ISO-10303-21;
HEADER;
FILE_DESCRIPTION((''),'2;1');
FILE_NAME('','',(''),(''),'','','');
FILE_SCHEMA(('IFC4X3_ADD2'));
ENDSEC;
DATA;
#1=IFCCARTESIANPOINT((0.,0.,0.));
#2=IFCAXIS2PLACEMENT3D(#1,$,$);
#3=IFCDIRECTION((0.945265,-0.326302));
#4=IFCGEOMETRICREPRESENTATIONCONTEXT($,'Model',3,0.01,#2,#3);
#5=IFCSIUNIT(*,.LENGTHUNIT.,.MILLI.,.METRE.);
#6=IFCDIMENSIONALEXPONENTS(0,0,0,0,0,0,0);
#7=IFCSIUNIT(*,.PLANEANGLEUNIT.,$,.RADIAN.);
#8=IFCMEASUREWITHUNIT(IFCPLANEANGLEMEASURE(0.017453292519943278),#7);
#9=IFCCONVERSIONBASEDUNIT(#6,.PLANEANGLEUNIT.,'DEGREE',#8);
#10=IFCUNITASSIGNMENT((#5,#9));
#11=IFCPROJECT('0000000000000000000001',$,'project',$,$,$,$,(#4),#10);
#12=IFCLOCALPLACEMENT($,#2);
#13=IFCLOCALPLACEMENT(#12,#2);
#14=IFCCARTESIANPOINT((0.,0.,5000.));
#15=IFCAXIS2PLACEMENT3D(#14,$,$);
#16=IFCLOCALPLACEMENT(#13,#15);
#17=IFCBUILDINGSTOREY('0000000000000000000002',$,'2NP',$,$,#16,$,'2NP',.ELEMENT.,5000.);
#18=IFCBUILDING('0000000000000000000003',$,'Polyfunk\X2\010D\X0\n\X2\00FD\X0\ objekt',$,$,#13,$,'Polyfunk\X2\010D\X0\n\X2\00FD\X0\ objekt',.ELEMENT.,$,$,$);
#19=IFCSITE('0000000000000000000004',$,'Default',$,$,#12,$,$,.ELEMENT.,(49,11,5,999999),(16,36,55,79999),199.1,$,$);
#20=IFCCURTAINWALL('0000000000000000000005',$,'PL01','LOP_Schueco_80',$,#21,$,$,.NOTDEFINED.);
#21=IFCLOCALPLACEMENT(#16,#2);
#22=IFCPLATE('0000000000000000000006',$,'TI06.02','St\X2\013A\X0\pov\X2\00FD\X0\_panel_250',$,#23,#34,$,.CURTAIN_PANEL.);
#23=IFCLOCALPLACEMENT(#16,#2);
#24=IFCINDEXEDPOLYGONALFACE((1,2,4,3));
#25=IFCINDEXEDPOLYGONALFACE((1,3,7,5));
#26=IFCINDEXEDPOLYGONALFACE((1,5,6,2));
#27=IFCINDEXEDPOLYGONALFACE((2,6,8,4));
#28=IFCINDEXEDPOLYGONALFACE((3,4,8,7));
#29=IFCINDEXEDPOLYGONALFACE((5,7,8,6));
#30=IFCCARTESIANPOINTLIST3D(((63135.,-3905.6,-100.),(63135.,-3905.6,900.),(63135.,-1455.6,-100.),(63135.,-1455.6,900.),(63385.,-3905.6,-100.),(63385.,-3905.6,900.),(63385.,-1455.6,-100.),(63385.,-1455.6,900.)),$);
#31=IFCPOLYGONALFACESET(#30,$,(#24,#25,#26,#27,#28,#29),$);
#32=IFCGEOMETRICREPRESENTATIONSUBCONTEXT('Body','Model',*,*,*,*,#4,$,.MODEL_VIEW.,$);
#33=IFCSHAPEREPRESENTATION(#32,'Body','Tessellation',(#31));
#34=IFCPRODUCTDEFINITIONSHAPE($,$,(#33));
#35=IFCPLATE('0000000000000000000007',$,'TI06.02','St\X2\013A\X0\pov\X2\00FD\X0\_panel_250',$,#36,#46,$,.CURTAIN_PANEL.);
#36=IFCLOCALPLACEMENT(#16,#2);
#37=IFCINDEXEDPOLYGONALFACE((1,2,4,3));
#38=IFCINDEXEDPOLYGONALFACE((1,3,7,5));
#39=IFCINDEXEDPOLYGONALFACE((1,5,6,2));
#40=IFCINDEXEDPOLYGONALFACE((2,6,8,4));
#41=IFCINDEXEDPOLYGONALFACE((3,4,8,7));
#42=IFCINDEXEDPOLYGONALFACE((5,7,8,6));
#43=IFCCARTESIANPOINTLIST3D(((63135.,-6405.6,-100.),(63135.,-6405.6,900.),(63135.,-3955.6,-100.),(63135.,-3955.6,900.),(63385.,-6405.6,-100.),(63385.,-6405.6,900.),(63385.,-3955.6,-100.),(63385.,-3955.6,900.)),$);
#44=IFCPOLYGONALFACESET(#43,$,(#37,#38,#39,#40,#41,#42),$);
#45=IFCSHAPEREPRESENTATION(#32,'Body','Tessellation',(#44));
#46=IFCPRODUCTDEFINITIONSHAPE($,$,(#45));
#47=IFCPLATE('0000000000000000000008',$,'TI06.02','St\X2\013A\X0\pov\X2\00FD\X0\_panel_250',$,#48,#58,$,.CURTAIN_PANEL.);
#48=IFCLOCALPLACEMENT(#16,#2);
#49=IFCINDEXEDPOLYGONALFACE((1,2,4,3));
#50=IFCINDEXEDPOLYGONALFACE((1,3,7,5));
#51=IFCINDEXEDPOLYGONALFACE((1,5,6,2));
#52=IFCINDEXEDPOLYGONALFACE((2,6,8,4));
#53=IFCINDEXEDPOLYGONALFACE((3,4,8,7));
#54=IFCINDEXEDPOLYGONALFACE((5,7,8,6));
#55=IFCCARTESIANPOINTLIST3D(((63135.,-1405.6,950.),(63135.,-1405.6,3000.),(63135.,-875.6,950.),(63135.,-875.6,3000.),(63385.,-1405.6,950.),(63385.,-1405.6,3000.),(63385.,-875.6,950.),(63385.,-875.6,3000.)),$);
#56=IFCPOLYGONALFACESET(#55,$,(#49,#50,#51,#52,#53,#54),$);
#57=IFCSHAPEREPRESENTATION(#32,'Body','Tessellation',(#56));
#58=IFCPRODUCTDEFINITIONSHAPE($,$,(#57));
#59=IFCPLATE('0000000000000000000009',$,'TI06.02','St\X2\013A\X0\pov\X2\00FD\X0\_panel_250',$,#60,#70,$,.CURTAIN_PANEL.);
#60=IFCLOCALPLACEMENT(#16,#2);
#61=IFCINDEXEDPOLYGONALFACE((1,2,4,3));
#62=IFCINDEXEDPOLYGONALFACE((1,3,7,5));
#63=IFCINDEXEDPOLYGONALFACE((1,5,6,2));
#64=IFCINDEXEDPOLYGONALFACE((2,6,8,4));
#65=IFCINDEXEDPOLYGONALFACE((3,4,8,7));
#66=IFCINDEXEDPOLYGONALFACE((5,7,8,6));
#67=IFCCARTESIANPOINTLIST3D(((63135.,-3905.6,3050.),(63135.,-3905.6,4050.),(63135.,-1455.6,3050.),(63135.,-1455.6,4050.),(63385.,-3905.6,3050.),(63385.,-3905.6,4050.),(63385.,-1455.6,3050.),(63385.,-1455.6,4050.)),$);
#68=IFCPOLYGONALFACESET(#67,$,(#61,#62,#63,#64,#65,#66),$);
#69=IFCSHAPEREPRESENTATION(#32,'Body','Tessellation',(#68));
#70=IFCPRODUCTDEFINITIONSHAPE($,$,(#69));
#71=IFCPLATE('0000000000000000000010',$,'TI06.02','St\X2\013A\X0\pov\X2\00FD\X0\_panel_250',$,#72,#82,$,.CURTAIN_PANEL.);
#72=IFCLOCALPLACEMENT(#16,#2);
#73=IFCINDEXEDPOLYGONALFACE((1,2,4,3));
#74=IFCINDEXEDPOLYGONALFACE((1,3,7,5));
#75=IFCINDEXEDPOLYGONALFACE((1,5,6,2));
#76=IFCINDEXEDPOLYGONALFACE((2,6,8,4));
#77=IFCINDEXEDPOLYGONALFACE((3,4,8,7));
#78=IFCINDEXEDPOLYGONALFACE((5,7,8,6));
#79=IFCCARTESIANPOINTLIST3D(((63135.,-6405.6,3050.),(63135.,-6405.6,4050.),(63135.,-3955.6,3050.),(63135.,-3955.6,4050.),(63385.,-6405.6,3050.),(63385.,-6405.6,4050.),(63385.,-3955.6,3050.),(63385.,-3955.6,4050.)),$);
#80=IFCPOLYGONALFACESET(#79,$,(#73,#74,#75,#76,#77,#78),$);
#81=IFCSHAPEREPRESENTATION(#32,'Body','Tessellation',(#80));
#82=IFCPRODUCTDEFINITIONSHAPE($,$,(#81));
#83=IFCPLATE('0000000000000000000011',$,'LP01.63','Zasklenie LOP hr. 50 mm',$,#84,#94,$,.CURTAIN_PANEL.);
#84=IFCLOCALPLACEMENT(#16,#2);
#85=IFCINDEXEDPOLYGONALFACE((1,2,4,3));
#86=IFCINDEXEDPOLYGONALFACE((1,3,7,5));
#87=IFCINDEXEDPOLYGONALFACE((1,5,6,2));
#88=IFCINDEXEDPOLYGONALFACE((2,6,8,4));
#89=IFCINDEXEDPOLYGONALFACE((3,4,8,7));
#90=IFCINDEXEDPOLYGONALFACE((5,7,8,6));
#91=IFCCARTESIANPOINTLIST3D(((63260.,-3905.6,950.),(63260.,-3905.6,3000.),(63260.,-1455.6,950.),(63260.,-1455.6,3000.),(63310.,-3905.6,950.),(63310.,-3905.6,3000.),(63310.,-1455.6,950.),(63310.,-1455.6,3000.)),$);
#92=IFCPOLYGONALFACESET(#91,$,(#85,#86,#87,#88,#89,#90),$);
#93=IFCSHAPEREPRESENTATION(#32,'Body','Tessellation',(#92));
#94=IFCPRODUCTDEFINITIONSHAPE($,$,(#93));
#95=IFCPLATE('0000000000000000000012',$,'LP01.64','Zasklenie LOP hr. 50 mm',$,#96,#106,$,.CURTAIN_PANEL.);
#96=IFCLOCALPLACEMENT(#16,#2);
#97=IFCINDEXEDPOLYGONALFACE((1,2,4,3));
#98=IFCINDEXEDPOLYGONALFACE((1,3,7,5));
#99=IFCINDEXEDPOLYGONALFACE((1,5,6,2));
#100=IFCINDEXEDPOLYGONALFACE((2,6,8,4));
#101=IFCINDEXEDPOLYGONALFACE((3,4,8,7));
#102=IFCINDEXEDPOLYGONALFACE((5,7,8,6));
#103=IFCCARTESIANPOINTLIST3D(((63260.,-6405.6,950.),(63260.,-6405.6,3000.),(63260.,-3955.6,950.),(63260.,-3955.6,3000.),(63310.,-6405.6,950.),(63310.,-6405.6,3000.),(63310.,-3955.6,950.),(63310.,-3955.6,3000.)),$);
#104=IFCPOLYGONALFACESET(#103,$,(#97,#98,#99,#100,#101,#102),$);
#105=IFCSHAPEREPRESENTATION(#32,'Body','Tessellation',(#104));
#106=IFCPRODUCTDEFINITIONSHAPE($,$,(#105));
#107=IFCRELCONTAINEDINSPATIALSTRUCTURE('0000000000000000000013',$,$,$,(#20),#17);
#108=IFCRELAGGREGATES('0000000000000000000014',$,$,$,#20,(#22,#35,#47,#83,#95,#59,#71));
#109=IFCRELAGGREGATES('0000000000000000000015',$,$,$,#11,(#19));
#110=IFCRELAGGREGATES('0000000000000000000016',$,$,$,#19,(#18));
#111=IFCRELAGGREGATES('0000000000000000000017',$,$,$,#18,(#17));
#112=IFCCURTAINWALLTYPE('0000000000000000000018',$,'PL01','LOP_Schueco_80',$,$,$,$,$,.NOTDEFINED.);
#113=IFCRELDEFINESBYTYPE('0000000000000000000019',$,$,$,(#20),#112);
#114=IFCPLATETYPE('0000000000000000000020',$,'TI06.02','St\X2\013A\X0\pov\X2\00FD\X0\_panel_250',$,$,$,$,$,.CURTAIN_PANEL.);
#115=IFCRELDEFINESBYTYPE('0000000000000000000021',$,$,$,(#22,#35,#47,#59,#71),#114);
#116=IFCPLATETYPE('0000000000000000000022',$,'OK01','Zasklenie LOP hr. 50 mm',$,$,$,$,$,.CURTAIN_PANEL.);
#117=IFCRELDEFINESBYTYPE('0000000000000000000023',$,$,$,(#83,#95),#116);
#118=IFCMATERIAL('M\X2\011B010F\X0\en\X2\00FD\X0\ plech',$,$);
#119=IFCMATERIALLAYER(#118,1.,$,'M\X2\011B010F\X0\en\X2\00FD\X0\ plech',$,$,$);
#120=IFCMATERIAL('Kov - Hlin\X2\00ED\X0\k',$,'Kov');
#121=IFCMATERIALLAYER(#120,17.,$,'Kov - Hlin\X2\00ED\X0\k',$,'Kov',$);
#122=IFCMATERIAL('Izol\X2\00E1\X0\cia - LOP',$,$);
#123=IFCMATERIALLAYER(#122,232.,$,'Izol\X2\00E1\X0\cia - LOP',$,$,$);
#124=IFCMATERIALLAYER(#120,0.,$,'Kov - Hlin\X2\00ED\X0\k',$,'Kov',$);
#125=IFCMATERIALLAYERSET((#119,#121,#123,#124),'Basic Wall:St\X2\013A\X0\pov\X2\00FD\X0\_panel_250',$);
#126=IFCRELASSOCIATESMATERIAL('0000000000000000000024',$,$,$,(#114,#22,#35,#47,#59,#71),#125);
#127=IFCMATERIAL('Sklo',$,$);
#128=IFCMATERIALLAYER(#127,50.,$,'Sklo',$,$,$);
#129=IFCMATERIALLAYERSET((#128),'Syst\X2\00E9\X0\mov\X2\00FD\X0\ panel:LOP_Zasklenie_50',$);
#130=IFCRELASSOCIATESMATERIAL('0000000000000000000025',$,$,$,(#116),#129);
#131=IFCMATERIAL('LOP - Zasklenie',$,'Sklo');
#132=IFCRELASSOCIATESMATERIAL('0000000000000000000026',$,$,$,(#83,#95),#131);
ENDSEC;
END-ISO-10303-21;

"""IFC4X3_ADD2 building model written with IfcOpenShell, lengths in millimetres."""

from ifc_helpers import new_model, entity, si_unit, converted_unit, direction, frame, frame_2d, origin, origin_2d_with_axis, place, context, subcontext, project, spatial, rectangle, extrude, source, transform, mapped, material, layer, layer_set, layer_usage, type_object, type_shapes, element, aggregate, save


model = new_model("IFC4X3_ADD2")

# Units and contexts
model_context = context("Model", 3, precision=0.01, world=origin(), true_north=direction((0.945265, -0.326302)))
body_context = subcontext(model_context, "Body", "Model", "MODEL_VIEW")
ifc_project = project(units=[si_unit("LENGTHUNIT", "METRE", prefix="MILLI"), converted_unit("PLANEANGLEUNIT", "DEGREE", entity("IfcPlaneAngleMeasure", 0.017453292519943278), si_unit("PLANEANGLEUNIT", "RADIAN"), dimensions=[0, 0, 0, 0, 0, 0, 0])], contexts=[model_context])

# Site, building, storey
site_placement = place(None, origin())
site = spatial("IfcSite", under=ifc_project, at=site_placement, Name="Default", CompositionType="ELEMENT", RefLatitude=(49, 11, 5, 999999), RefLongitude=(16, 36, 55, 79999), RefElevation=199.1)
building_placement = place(site_placement, origin())
building = spatial("IfcBuilding", under=site, at=building_placement, Name="Polyfunkčný objekt", LongName="Polyfunkčný objekt", CompositionType="ELEMENT")
storey_placement = place(building_placement, frame((0.0, 0.0, 5000.0)))
storey = spatial("IfcBuildingStorey", under=building, at=storey_placement, Name="2NP", LongName="2NP", CompositionType="ELEMENT", Elevation=5000.0)

# Curtain wall, plates
curtain_wall_type = type_object("IfcCurtainWallType", Name="PL01", Description="LOP_Schueco_80", PredefinedType="NOTDEFINED")
curtain_wall_placement = place(storey_placement, frame((0.0, 0.0, -5000.0)))
curtain_wall = element("IfcCurtainWall", 1, at=curtain_wall_placement, inside=storey, type_object=curtain_wall_type, Name="PL01", Description="LOP_Schueco_80", PredefinedType="NOTDEFINED")
ifc_material_1 = material(Name="Měďený plech")
ifc_layer_1 = layer(ifc_material_1, 1.0, Name="Měďený plech")
ifc_material_2 = material(Name="Kov - Hliník", Category="Kov")
ifc_layer_2 = layer(ifc_material_2, 17.0, Name="Kov - Hliník", Category="Kov")
ifc_material_3 = material(Name="Izolácia - LOP")
ifc_layer_3 = layer(ifc_material_3, 232.0, Name="Izolácia - LOP")
ifc_layer_4 = layer(ifc_material_2, 0.0, Name="Kov - Hliník", Category="Kov")
ifc_layer_set_1 = layer_set([ifc_layer_1, ifc_layer_2, ifc_layer_3, ifc_layer_4], Name="Basic Wall:Stĺpový_panel_250")
ifc_layer_usage_1 = layer_usage(ifc_layer_set_1, "AXIS2", "NEGATIVE", 125.0)
plate_type_1 = type_object("IfcPlateType", Name="TI06.02", Description="Stĺpový_panel_250", PredefinedType="CURTAIN_PANEL", material=ifc_layer_set_1)
plate_1_placement = place(storey_placement, frame((63260.0, -1455.6, -100.0), z_axis=(0.0, 0.0, 1.0), x_axis=(0.0, -1.0, 0.0)))
plate_1 = element("IfcPlate", 2, at=plate_1_placement, type_object=plate_type_1, material=ifc_layer_usage_1, Name="TI06.02", Description="Stĺpový_panel_250", PredefinedType="CURTAIN_PANEL", context=body_context, shape_type="SweptSolid", body=[
    extrude(rectangle(XDim=250.0, YDim=2450.0, at=frame_2d((0.0, 0.0), x_axis=(1.0, 0.0))), frame((1225.0, 0.0, 0.0), z_axis=(0.0, 0.0, 1.0), x_axis=(0.0, 1.0, 0.0)), (0.0, 0.0, 1.0), 1000.0),
])
ifc_layer_usage_2 = layer_usage(ifc_layer_set_1, "AXIS2", "NEGATIVE", 125.0)
plate_2_placement = place(storey_placement, frame((63260.0, -3955.6, -100.0), z_axis=(0.0, 0.0, 1.0), x_axis=(0.0, -1.0, 0.0)))
plate_2 = element("IfcPlate", 3, at=plate_2_placement, type_object=plate_type_1, material=ifc_layer_usage_2, Name="TI06.02", Description="Stĺpový_panel_250", PredefinedType="CURTAIN_PANEL", context=body_context, shape_type="SweptSolid", body=[
    extrude(rectangle(XDim=250.0, YDim=2450.0, at=frame_2d((0.0, 0.0), x_axis=(1.0, 0.0))), frame((1225.0, 0.0, 0.0), z_axis=(0.0, 0.0, 1.0), x_axis=(0.0, 1.0, 0.0)), (0.0, 0.0, 1.0), 1000.0),
])
ifc_layer_usage_3 = layer_usage(ifc_layer_set_1, "AXIS2", "NEGATIVE", 125.0)
plate_3_placement = place(storey_placement, frame((63260.0, -875.6, 950.0), z_axis=(0.0, 0.0, 1.0), x_axis=(0.0, -1.0, 0.0)))
plate_3 = element("IfcPlate", 4, at=plate_3_placement, type_object=plate_type_1, material=ifc_layer_usage_3, Name="TI06.02", Description="Stĺpový_panel_250", PredefinedType="CURTAIN_PANEL", context=body_context, shape_type="SweptSolid", body=[
    extrude(rectangle(XDim=250.0, YDim=530.0, at=frame_2d((0.0, 0.0), x_axis=(1.0, 0.0))), frame((265.0, 0.0, 0.0), z_axis=(0.0, 0.0, 1.0), x_axis=(0.0, 1.0, 0.0)), (0.0, 0.0, 1.0), 2050.0),
])
ifc_layer_usage_4 = layer_usage(ifc_layer_set_1, "AXIS2", "NEGATIVE", 125.0)
plate_4_placement = place(storey_placement, frame((63260.0, -1455.6, 3050.0), z_axis=(0.0, 0.0, 1.0), x_axis=(0.0, -1.0, 0.0)))
plate_4 = element("IfcPlate", 5, at=plate_4_placement, type_object=plate_type_1, material=ifc_layer_usage_4, Name="TI06.02", Description="Stĺpový_panel_250", PredefinedType="CURTAIN_PANEL", context=body_context, shape_type="SweptSolid", body=[
    extrude(rectangle(XDim=250.0, YDim=2450.0, at=frame_2d((0.0, 0.0), x_axis=(1.0, 0.0))), frame((1225.0, 0.0, 0.0), z_axis=(0.0, 0.0, 1.0), x_axis=(0.0, 1.0, 0.0)), (0.0, 0.0, 1.0), 1000.0),
])
ifc_layer_usage_5 = layer_usage(ifc_layer_set_1, "AXIS2", "NEGATIVE", 125.0)
plate_5_placement = place(storey_placement, frame((63260.0, -3955.6, 3050.0), z_axis=(0.0, 0.0, 1.0), x_axis=(0.0, -1.0, 0.0)))
plate_5 = element("IfcPlate", 6, at=plate_5_placement, type_object=plate_type_1, material=ifc_layer_usage_5, Name="TI06.02", Description="Stĺpový_panel_250", PredefinedType="CURTAIN_PANEL", context=body_context, shape_type="SweptSolid", body=[
    extrude(rectangle(XDim=250.0, YDim=2450.0, at=frame_2d((0.0, 0.0), x_axis=(1.0, 0.0))), frame((1225.0, 0.0, 0.0), z_axis=(0.0, 0.0, 1.0), x_axis=(0.0, 1.0, 0.0)), (0.0, 0.0, 1.0), 1000.0),
])
ifc_material_4 = material(Name="LOP - Zasklenie", Category="Sklo")
ifc_material_5 = material(Name="Sklo")
ifc_layer_5 = layer(ifc_material_5, 50.0, Name="Sklo")
ifc_layer_set_2 = layer_set([ifc_layer_5], Name="Systémový panel:LOP_Zasklenie_50")
plate_type_2 = type_object("IfcPlateType", Name="OK01", Description="Zasklenie LOP hr. 50 mm", PredefinedType="CURTAIN_PANEL", material=ifc_layer_set_2)
shared_shape_1 = source(origin(), body_context, "Body", "SweptSolid", [
    extrude(rectangle(XDim=50.0, YDim=2450.0, at=origin_2d_with_axis()), frame((0.0, 25.0, 0.0), z_axis=(0.0, 0.0, 1.0), x_axis=(0.0, 1.0, 0.0)), (0.0, 0.0, 1.0), 2050.0),
])
type_shapes(plate_type_2, [shared_shape_1])
plate_6_placement = place(curtain_wall_placement, frame((63260.0, -2680.6, 5950.0), z_axis=(0.0, 0.0, 1.0), x_axis=(0.0, -1.0, 0.0)))
plate_6 = element("IfcPlate", 7, at=plate_6_placement, type_object=plate_type_2, material=ifc_material_4, Name="LP01.63", Description="Zasklenie LOP hr. 50 mm", PredefinedType="CURTAIN_PANEL", context=body_context, shape_type="MappedRepresentation", body=[
    mapped(shared_shape_1, transform((0.0, 0.0, 0.0), scale=1.0)),
])
plate_7_placement = place(curtain_wall_placement, frame((63260.0, -5180.6, 5950.0), z_axis=(0.0, 0.0, 1.0), x_axis=(0.0, -1.0, 0.0)))
plate_7 = element("IfcPlate", 8, at=plate_7_placement, type_object=plate_type_2, material=ifc_material_4, Name="LP01.64", Description="Zasklenie LOP hr. 50 mm", PredefinedType="CURTAIN_PANEL", context=body_context, shape_type="MappedRepresentation", body=[
    mapped(shared_shape_1, transform((0.0, 0.0, 0.0), scale=1.0)),
])
aggregate(curtain_wall, [plate_1, plate_2, plate_3, plate_6, plate_7, plate_4, plate_5])

save(model, "model.ifc")
